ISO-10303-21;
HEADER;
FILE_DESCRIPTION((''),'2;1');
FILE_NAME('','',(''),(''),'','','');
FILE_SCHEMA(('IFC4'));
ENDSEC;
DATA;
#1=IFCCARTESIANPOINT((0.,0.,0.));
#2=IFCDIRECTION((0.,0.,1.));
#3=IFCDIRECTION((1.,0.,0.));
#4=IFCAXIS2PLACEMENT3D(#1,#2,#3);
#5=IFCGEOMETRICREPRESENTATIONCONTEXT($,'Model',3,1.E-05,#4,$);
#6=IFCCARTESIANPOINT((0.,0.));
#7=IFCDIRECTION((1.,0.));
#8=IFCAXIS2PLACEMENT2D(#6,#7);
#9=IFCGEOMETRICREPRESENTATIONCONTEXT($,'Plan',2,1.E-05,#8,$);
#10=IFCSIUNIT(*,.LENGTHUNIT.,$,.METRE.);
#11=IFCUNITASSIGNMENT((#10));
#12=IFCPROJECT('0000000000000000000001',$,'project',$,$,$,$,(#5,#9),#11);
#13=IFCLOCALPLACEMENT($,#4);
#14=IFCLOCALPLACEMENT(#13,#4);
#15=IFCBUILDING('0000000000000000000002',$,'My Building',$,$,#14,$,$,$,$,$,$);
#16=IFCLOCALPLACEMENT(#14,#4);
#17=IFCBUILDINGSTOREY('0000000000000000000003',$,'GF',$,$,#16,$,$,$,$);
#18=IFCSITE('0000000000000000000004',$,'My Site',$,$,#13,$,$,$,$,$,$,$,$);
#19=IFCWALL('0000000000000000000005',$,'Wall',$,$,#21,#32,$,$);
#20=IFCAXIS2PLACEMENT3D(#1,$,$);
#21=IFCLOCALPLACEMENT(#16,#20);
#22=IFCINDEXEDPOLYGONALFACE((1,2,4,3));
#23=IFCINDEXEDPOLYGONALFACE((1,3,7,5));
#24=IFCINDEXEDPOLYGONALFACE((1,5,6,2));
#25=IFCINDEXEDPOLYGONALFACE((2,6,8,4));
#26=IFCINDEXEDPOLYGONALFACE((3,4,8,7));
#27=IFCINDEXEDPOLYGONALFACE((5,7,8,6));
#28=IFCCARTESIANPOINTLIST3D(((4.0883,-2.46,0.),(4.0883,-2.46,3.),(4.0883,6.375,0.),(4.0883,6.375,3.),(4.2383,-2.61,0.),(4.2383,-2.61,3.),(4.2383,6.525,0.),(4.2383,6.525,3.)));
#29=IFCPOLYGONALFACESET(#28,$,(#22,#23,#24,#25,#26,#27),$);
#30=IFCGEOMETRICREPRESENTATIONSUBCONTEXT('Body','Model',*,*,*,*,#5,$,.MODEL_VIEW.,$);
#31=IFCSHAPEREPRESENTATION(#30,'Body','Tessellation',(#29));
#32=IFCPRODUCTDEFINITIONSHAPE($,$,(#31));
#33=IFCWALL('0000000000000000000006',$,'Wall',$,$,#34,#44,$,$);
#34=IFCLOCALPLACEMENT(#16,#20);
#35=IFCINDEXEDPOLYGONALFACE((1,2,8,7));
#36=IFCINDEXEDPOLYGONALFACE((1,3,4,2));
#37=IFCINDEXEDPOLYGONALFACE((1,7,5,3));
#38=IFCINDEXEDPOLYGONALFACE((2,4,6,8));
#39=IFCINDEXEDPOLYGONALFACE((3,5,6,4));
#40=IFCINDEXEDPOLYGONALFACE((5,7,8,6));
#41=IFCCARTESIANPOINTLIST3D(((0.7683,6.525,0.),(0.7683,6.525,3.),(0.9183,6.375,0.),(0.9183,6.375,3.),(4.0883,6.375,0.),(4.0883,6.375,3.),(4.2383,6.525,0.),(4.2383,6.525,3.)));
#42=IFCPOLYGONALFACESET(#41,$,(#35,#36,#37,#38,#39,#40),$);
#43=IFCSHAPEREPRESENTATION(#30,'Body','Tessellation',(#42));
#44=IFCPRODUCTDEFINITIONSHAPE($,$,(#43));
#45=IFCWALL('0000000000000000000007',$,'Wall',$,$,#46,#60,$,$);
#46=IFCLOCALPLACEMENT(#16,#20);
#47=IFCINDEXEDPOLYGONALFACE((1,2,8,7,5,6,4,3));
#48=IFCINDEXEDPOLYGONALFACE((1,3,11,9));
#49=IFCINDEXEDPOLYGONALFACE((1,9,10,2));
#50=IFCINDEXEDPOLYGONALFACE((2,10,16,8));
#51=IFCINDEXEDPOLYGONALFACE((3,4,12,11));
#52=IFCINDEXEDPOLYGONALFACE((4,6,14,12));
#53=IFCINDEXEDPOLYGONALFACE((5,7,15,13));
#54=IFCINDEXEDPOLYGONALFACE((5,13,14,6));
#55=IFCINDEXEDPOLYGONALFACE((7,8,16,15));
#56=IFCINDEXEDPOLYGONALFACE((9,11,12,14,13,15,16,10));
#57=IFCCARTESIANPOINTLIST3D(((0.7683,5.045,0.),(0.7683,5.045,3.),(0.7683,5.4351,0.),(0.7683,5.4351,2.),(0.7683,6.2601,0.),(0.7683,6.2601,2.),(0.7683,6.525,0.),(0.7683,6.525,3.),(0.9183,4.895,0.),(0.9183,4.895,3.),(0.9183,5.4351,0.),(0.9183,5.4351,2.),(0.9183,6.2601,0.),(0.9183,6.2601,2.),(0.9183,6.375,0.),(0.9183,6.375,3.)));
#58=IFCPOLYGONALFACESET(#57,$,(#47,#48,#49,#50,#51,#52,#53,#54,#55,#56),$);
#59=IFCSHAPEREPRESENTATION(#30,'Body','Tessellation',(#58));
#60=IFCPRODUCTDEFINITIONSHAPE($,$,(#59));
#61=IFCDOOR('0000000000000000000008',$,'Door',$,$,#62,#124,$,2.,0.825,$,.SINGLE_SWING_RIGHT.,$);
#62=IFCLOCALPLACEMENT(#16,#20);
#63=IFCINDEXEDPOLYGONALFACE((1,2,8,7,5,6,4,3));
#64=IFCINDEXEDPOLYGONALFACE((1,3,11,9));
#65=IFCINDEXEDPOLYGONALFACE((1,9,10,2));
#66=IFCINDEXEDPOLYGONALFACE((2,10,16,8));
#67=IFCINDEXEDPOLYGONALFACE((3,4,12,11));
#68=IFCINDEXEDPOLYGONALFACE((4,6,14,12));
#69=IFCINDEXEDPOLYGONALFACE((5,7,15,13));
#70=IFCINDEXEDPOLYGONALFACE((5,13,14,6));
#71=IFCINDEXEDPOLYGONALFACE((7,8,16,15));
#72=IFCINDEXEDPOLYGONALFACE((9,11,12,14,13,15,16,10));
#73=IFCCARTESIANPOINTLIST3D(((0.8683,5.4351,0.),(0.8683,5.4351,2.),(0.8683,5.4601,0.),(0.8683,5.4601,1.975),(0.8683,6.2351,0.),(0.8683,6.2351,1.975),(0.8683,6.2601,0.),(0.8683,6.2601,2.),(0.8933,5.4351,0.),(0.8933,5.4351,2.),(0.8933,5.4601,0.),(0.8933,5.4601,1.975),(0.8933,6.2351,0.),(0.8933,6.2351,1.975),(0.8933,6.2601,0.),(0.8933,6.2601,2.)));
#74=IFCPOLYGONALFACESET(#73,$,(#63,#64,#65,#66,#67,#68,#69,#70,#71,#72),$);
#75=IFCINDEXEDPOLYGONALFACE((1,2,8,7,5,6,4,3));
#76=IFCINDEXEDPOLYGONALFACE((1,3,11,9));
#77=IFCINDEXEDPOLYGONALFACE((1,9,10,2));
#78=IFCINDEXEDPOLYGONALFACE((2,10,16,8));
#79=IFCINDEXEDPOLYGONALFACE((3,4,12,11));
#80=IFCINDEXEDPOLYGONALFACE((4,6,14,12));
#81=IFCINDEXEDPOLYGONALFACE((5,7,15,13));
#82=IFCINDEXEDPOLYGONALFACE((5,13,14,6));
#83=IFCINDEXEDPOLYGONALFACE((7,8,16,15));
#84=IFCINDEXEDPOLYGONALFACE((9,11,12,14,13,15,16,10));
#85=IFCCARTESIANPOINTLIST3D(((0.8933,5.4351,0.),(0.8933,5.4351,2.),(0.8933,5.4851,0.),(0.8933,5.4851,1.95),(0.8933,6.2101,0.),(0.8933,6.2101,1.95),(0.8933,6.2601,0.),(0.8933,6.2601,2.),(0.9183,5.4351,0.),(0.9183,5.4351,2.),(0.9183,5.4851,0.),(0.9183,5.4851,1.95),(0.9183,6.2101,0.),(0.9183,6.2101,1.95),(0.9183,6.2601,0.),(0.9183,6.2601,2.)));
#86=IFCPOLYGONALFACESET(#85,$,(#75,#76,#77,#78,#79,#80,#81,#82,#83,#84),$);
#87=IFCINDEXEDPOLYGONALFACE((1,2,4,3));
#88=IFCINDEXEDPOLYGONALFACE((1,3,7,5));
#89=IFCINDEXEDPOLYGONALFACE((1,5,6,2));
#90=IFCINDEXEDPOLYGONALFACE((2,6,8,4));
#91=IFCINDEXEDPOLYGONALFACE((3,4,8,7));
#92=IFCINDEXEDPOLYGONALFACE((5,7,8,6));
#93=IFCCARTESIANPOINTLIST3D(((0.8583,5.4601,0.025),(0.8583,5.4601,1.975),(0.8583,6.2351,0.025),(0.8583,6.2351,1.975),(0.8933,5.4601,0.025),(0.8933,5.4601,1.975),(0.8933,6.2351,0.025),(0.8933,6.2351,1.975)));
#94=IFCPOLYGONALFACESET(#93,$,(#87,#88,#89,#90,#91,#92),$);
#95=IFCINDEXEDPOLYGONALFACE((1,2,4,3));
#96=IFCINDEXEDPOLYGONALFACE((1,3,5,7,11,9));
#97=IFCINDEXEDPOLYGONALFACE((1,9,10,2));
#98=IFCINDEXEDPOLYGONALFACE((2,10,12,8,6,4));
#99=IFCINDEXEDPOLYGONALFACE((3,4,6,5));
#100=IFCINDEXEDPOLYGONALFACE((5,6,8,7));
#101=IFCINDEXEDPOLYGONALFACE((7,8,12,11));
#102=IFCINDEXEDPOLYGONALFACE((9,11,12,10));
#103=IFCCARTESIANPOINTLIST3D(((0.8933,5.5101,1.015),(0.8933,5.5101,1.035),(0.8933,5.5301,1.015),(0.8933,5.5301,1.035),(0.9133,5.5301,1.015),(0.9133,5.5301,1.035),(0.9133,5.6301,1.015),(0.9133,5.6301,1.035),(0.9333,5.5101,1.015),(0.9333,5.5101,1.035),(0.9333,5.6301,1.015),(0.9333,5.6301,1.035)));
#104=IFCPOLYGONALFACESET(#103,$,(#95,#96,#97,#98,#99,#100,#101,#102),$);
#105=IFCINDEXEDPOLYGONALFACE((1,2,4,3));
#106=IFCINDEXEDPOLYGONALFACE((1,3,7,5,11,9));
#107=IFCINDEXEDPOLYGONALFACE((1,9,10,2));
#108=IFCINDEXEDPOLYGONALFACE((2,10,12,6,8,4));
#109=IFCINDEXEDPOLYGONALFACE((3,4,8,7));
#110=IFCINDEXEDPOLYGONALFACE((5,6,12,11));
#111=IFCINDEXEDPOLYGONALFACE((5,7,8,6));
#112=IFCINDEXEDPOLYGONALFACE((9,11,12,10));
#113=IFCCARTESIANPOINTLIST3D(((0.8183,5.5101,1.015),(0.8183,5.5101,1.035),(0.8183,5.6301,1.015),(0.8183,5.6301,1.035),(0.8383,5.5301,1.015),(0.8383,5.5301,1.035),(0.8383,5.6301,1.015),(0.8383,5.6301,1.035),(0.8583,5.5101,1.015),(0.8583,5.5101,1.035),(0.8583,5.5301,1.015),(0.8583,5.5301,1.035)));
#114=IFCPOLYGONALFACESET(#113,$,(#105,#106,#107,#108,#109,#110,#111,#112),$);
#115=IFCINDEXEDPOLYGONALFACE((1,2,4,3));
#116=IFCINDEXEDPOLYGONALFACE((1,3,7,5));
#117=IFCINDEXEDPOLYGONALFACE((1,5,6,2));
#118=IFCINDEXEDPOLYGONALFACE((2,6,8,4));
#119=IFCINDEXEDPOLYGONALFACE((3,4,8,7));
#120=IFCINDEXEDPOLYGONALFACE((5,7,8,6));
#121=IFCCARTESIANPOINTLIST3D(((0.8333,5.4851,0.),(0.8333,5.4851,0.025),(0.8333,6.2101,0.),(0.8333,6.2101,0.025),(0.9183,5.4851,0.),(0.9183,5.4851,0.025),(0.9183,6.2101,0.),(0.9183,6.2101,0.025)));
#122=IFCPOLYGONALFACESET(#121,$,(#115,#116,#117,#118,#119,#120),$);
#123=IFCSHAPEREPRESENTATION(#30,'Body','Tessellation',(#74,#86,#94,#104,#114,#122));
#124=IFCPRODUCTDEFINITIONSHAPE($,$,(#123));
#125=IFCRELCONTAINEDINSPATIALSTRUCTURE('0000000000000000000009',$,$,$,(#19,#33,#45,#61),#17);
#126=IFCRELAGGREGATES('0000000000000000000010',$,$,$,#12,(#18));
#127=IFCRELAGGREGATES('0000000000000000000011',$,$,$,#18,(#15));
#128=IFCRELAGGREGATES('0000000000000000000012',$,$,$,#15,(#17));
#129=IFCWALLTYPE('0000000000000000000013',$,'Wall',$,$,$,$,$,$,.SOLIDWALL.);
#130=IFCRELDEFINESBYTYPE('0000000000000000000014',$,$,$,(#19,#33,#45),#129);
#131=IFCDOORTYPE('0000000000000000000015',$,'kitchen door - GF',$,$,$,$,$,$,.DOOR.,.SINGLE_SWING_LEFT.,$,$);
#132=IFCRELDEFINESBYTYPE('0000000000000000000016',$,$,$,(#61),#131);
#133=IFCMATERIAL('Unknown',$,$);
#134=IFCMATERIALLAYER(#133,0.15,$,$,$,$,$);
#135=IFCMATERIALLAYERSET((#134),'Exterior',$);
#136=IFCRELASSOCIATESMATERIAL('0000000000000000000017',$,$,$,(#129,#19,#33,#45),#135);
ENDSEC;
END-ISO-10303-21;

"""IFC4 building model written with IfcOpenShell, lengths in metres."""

from ifc_helpers import new_model, entity, si_unit, frame, origin_with_axes, origin_2d_with_axis, place, context, subcontext, project, spatial, line, indexed_curve, outline, extrude, shape, source, transform, mapped, material, layer, layer_set, layer_usage, type_object, type_shapes, element, fill, save


model = new_model("IFC4")

# Units and contexts
model_context = context("Model", 3, precision=1e-05, world=origin_with_axes())
plan_context = context("Plan", 2, precision=1e-05, world=origin_2d_with_axis())
body_context_1 = subcontext(model_context, "Body", "Model", "MODEL_VIEW")
body_context_2 = subcontext(plan_context, "Body", "Plan", "PLAN_VIEW")
ifc_project = project(units=[si_unit("LENGTHUNIT", "METRE")], contexts=[model_context, plan_context])

# Site, building, storey
site_placement = place(None, origin_with_axes())
site = spatial("IfcSite", under=ifc_project, at=site_placement, Name="My Site")
building_placement = place(site_placement, origin_with_axes())
building = spatial("IfcBuilding", under=site, at=building_placement, Name="My Building")
storey_placement = place(building_placement, origin_with_axes())
storey = spatial("IfcBuildingStorey", under=building, at=storey_placement, Name="GF")

# Shared definitions
ifc_material = material(Name="Unknown")
ifc_layer_1 = layer(ifc_material, 0.15)
ifc_layer_set_1 = layer_set([ifc_layer_1], Name="Exterior")
wall_type_1 = type_object("IfcWallType", Name="Wall", PredefinedType="SOLIDWALL", material=ifc_layer_set_1)

# Walls
ifc_layer_usage_1 = layer_usage(ifc_layer_set_1, "AXIS2", "POSITIVE", 0.0)
wall_1_placement = place(storey_placement, frame((4.2383, -2.61, 0.0), z_axis=(0.0, 0.0, 1.0), x_axis=(0.0, 1.0, 0.0)))
element("IfcWall", 1, at=wall_1_placement, inside=storey, type_object=wall_type_1, material=ifc_layer_usage_1, Name="Wall", context=body_context_1, shape_type="SweptSolid", body=[
    extrude(outline(indexed_curve([(0.0, 0.0), (0.15, 0.15), (8.985, 0.15), (9.135, 0.0)], segments=[line(1, 2, 3, 4, 1)])), origin_with_axes(), (0.0, 0.0, 1.0), 3.0),
])
ifc_layer_usage_2 = layer_usage(ifc_layer_set_1, "AXIS2", "POSITIVE", 0.0)
wall_2_placement = place(storey_placement, frame((4.2383, 6.525, 0.0), z_axis=(0.0, 0.0, 1.0), x_axis=(-1.0, 0.0, 0.0)))
element("IfcWall", 2, at=wall_2_placement, inside=storey, type_object=wall_type_1, material=ifc_layer_usage_2, Name="Wall", context=body_context_1, shape_type="SweptSolid", body=[
    extrude(outline(indexed_curve([(0.0, 0.0), (0.15, 0.15), (3.32, 0.15), (3.47, 0.0)], segments=[line(1, 2, 3, 4, 1)])), origin_with_axes(), (0.0, 0.0, 1.0), 3.0),
])

# Wall, opening, door
ifc_layer_usage_3 = layer_usage(ifc_layer_set_1, "AXIS2", "POSITIVE", 0.0)
wall_3_placement = place(storey_placement, frame((0.7683, 6.525, 0.0), z_axis=(0.0, 0.0, 1.0), x_axis=(0.0, -1.0, 0.0)))
wall_3 = element("IfcWall", 3, at=wall_3_placement, inside=storey, type_object=wall_type_1, material=ifc_layer_usage_3, Name="Wall", context=body_context_1, shape_type="SweptSolid", body=[
    extrude(outline(indexed_curve([(0.0, 0.0), (0.15, 0.15), (1.63, 0.15), (1.48, 0.0)], segments=[line(1, 2, 3, 4, 1)])), origin_with_axes(), (0.0, 0.0, 1.0), 3.0),
])
shared_shape_1 = source(origin_with_axes(), body_context_1, "Body", "SweptSolid", [
    extrude(outline(indexed_curve([(0.0, 0.0), (0.825, 0.0), (0.825, 2.0), (0.0, 2.0)], segments=[line(1, 2, 3, 4, 1)])), frame((0.0, -0.6, 0.0), z_axis=(0.0, -1.0, 0.0), x_axis=(1.0, 0.0, 0.0)), (0.0, 0.0, -1.0), 1.2),
])
opening_1_placement = place(wall_3_placement, frame((1.0898, 0.15, 0.0), z_axis=(0.0, 0.0, 1.0), x_axis=(-1.0, 0.0, 0.0)))
opening_1 = element("IfcOpeningElement", 4, at=opening_1_placement, cuts=wall_3, PredefinedType="OPENING", context=body_context_1, shape_type="MappedRepresentation", body=[
    mapped(shared_shape_1, transform((0.0, 0.0, 0.0), x_axis=(1.0, 0.0, 0.0), y_axis=(0.0, 1.0, 0.0), z_axis=(0.0, 0.0, 1.0), scale=1.0)),
])
door_type_1 = type_object("IfcDoorType", Name="kitchen door - GF", OperationType="SINGLE_SWING_LEFT", PredefinedType="DOOR")
shared_shape_2 = source(origin_with_axes(), body_context_1, "Body", "SweptSolid", [
    extrude(outline(indexed_curve([(0.0, 0.0), (0.0, 2.0), (0.825, 2.0), (0.825, 0.0), (0.8, 0.0), (0.8, 1.975), (0.025, 1.975), (0.025, 0.0)], segments=[line(1, 2, 3, 4, 5, 6, 7, 8, 1)])), frame((0.0, 0.025, 0.0), z_axis=(0.0, -1.0, 0.0), x_axis=(1.0, 0.0, 0.0)), (0.0, 0.0, -1.0), 0.025),
    extrude(outline(indexed_curve([(0.0, 0.0), (0.0, 2.0), (0.825, 2.0), (0.825, 0.0), (0.775, 0.0), (0.775, 1.95), (0.05, 1.95), (0.05, 0.0)], segments=[line(1, 2, 3, 4, 5, 6, 7, 8, 1)])), frame((0.0, 0.0, 0.0), z_axis=(0.0, -1.0, 0.0), x_axis=(1.0, 0.0, 0.0)), (0.0, 0.0, -1.0), 0.025),
    extrude(outline(indexed_curve([(0.0, 0.0), (0.775, 0.0), (0.775, 0.035), (0.0, 0.035)], segments=[line(1, 2, 3, 4, 1)])), frame((0.025, 0.025, 0.025), z_axis=(0.0, 0.0, 1.0), x_axis=(1.0, 0.0, 0.0)), (0.0, 0.0, 1.0), 1.95),
    extrude(outline(indexed_curve([(0.0, 0.0), (0.0, -0.04), (0.12, -0.04), (0.12, -0.02), (0.02, -0.02), (0.02, 0.0)], segments=[line(1, 2, 3, 4, 5, 6, 1)])), frame((0.075, 0.025, 1.015), z_axis=(0.0, 0.0, 1.0), x_axis=(1.0, 0.0, 0.0)), (0.0, 0.0, 1.0), 0.02),
    extrude(outline(indexed_curve([(0.0, 0.0), (0.0, 0.04), (0.12, 0.04), (0.12, 0.02), (0.02, 0.02), (0.02, 0.0)], segments=[line(1, 2, 3, 4, 5, 6, 1)])), frame((0.075, 0.06, 1.015), z_axis=(0.0, 0.0, 1.0), x_axis=(1.0, 0.0, 0.0)), (0.0, 0.0, 1.0), 0.02),
    extrude(outline(indexed_curve([(0.0, 0.0), (0.725, 0.0), (0.725, 0.085), (0.0, 0.085)], segments=[line(1, 2, 3, 4, 1)])), frame((0.05, 0.0, 0.0), z_axis=(0.0, 0.0, 1.0), x_axis=(1.0, 0.0, 0.0)), (0.0, 0.0, 1.0), 0.025),
])
shared_shape_3 = source(origin_with_axes(), body_context_2, "Body", "Curve2D", [
    entity("IfcIndexedPolyCurve", entity("IfcCartesianPointList2D", [[0.0, 0.0], [0.0, 0.05], [0.025, 0.05], [0.025, 0.025], [0.05, 0.025], [0.05, 0.0]]), [entity("IfcLineIndex", [1, 2, 3, 4, 5, 6, 1])]),
    entity("IfcIndexedPolyCurve", entity("IfcCartesianPointList2D", [[0.825, 0.0], [0.825, 0.05], [0.8, 0.05], [0.8, 0.025], [0.775, 0.025], [0.775, 0.0]]), [entity("IfcLineIndex", [1, 2, 3, 4, 5, 6, 1])]),
    entity("IfcTrimmedCurve", entity("IfcEllipse", entity("IfcAxis2Placement2D", entity("IfcCartesianPoint", [0.765, 0.05]), entity("IfcDirection", [1.0, 0.0])), 0.74, 0.775), [entity("IfcCartesianPoint", [0.765, 0.825])], [entity("IfcCartesianPoint", [0.025, 0.05])], True, "CARTESIAN"),
    entity("IfcIndexedPolyCurve", entity("IfcCartesianPointList2D", [[0.8, 0.05], [0.765, 0.05], [0.765, 0.825], [0.8, 0.825]]), [entity("IfcLineIndex", [1, 2, 3, 4, 1])]),
])
type_shapes(door_type_1, [shared_shape_2, shared_shape_3])
door_1_placement = place(opening_1_placement, frame((0.0, 0.0, 0.0), z_axis=(0.0, 0.0, 1.0), x_axis=(1.0, 0.0, 0.0)))
door_1 = element("IfcDoor", 5, at=door_1_placement, inside=storey, type_object=door_type_1, Name="Door", OperationType="SINGLE_SWING_RIGHT", OverallHeight=2.0, OverallWidth=0.825, shapes=[
    shape(body_context_1, "Body", "MappedRepresentation", [mapped(shared_shape_2, transform((0.0, 0.0, 0.0), x_axis=(1.0, 0.0, 0.0), y_axis=(0.0, 1.0, 0.0), z_axis=(0.0, 0.0, 1.0), scale=1.0))]),
    shape(body_context_2, "Body", "MappedRepresentation", [mapped(shared_shape_3, transform((0.0, 0.0, 0.0), x_axis=(1.0, 0.0, 0.0), y_axis=(0.0, 1.0, 0.0), z_axis=(0.0, 0.0, 1.0), scale=1.0))]),
])
fill(opening_1, door_1)

save(model, "model.ifc")
